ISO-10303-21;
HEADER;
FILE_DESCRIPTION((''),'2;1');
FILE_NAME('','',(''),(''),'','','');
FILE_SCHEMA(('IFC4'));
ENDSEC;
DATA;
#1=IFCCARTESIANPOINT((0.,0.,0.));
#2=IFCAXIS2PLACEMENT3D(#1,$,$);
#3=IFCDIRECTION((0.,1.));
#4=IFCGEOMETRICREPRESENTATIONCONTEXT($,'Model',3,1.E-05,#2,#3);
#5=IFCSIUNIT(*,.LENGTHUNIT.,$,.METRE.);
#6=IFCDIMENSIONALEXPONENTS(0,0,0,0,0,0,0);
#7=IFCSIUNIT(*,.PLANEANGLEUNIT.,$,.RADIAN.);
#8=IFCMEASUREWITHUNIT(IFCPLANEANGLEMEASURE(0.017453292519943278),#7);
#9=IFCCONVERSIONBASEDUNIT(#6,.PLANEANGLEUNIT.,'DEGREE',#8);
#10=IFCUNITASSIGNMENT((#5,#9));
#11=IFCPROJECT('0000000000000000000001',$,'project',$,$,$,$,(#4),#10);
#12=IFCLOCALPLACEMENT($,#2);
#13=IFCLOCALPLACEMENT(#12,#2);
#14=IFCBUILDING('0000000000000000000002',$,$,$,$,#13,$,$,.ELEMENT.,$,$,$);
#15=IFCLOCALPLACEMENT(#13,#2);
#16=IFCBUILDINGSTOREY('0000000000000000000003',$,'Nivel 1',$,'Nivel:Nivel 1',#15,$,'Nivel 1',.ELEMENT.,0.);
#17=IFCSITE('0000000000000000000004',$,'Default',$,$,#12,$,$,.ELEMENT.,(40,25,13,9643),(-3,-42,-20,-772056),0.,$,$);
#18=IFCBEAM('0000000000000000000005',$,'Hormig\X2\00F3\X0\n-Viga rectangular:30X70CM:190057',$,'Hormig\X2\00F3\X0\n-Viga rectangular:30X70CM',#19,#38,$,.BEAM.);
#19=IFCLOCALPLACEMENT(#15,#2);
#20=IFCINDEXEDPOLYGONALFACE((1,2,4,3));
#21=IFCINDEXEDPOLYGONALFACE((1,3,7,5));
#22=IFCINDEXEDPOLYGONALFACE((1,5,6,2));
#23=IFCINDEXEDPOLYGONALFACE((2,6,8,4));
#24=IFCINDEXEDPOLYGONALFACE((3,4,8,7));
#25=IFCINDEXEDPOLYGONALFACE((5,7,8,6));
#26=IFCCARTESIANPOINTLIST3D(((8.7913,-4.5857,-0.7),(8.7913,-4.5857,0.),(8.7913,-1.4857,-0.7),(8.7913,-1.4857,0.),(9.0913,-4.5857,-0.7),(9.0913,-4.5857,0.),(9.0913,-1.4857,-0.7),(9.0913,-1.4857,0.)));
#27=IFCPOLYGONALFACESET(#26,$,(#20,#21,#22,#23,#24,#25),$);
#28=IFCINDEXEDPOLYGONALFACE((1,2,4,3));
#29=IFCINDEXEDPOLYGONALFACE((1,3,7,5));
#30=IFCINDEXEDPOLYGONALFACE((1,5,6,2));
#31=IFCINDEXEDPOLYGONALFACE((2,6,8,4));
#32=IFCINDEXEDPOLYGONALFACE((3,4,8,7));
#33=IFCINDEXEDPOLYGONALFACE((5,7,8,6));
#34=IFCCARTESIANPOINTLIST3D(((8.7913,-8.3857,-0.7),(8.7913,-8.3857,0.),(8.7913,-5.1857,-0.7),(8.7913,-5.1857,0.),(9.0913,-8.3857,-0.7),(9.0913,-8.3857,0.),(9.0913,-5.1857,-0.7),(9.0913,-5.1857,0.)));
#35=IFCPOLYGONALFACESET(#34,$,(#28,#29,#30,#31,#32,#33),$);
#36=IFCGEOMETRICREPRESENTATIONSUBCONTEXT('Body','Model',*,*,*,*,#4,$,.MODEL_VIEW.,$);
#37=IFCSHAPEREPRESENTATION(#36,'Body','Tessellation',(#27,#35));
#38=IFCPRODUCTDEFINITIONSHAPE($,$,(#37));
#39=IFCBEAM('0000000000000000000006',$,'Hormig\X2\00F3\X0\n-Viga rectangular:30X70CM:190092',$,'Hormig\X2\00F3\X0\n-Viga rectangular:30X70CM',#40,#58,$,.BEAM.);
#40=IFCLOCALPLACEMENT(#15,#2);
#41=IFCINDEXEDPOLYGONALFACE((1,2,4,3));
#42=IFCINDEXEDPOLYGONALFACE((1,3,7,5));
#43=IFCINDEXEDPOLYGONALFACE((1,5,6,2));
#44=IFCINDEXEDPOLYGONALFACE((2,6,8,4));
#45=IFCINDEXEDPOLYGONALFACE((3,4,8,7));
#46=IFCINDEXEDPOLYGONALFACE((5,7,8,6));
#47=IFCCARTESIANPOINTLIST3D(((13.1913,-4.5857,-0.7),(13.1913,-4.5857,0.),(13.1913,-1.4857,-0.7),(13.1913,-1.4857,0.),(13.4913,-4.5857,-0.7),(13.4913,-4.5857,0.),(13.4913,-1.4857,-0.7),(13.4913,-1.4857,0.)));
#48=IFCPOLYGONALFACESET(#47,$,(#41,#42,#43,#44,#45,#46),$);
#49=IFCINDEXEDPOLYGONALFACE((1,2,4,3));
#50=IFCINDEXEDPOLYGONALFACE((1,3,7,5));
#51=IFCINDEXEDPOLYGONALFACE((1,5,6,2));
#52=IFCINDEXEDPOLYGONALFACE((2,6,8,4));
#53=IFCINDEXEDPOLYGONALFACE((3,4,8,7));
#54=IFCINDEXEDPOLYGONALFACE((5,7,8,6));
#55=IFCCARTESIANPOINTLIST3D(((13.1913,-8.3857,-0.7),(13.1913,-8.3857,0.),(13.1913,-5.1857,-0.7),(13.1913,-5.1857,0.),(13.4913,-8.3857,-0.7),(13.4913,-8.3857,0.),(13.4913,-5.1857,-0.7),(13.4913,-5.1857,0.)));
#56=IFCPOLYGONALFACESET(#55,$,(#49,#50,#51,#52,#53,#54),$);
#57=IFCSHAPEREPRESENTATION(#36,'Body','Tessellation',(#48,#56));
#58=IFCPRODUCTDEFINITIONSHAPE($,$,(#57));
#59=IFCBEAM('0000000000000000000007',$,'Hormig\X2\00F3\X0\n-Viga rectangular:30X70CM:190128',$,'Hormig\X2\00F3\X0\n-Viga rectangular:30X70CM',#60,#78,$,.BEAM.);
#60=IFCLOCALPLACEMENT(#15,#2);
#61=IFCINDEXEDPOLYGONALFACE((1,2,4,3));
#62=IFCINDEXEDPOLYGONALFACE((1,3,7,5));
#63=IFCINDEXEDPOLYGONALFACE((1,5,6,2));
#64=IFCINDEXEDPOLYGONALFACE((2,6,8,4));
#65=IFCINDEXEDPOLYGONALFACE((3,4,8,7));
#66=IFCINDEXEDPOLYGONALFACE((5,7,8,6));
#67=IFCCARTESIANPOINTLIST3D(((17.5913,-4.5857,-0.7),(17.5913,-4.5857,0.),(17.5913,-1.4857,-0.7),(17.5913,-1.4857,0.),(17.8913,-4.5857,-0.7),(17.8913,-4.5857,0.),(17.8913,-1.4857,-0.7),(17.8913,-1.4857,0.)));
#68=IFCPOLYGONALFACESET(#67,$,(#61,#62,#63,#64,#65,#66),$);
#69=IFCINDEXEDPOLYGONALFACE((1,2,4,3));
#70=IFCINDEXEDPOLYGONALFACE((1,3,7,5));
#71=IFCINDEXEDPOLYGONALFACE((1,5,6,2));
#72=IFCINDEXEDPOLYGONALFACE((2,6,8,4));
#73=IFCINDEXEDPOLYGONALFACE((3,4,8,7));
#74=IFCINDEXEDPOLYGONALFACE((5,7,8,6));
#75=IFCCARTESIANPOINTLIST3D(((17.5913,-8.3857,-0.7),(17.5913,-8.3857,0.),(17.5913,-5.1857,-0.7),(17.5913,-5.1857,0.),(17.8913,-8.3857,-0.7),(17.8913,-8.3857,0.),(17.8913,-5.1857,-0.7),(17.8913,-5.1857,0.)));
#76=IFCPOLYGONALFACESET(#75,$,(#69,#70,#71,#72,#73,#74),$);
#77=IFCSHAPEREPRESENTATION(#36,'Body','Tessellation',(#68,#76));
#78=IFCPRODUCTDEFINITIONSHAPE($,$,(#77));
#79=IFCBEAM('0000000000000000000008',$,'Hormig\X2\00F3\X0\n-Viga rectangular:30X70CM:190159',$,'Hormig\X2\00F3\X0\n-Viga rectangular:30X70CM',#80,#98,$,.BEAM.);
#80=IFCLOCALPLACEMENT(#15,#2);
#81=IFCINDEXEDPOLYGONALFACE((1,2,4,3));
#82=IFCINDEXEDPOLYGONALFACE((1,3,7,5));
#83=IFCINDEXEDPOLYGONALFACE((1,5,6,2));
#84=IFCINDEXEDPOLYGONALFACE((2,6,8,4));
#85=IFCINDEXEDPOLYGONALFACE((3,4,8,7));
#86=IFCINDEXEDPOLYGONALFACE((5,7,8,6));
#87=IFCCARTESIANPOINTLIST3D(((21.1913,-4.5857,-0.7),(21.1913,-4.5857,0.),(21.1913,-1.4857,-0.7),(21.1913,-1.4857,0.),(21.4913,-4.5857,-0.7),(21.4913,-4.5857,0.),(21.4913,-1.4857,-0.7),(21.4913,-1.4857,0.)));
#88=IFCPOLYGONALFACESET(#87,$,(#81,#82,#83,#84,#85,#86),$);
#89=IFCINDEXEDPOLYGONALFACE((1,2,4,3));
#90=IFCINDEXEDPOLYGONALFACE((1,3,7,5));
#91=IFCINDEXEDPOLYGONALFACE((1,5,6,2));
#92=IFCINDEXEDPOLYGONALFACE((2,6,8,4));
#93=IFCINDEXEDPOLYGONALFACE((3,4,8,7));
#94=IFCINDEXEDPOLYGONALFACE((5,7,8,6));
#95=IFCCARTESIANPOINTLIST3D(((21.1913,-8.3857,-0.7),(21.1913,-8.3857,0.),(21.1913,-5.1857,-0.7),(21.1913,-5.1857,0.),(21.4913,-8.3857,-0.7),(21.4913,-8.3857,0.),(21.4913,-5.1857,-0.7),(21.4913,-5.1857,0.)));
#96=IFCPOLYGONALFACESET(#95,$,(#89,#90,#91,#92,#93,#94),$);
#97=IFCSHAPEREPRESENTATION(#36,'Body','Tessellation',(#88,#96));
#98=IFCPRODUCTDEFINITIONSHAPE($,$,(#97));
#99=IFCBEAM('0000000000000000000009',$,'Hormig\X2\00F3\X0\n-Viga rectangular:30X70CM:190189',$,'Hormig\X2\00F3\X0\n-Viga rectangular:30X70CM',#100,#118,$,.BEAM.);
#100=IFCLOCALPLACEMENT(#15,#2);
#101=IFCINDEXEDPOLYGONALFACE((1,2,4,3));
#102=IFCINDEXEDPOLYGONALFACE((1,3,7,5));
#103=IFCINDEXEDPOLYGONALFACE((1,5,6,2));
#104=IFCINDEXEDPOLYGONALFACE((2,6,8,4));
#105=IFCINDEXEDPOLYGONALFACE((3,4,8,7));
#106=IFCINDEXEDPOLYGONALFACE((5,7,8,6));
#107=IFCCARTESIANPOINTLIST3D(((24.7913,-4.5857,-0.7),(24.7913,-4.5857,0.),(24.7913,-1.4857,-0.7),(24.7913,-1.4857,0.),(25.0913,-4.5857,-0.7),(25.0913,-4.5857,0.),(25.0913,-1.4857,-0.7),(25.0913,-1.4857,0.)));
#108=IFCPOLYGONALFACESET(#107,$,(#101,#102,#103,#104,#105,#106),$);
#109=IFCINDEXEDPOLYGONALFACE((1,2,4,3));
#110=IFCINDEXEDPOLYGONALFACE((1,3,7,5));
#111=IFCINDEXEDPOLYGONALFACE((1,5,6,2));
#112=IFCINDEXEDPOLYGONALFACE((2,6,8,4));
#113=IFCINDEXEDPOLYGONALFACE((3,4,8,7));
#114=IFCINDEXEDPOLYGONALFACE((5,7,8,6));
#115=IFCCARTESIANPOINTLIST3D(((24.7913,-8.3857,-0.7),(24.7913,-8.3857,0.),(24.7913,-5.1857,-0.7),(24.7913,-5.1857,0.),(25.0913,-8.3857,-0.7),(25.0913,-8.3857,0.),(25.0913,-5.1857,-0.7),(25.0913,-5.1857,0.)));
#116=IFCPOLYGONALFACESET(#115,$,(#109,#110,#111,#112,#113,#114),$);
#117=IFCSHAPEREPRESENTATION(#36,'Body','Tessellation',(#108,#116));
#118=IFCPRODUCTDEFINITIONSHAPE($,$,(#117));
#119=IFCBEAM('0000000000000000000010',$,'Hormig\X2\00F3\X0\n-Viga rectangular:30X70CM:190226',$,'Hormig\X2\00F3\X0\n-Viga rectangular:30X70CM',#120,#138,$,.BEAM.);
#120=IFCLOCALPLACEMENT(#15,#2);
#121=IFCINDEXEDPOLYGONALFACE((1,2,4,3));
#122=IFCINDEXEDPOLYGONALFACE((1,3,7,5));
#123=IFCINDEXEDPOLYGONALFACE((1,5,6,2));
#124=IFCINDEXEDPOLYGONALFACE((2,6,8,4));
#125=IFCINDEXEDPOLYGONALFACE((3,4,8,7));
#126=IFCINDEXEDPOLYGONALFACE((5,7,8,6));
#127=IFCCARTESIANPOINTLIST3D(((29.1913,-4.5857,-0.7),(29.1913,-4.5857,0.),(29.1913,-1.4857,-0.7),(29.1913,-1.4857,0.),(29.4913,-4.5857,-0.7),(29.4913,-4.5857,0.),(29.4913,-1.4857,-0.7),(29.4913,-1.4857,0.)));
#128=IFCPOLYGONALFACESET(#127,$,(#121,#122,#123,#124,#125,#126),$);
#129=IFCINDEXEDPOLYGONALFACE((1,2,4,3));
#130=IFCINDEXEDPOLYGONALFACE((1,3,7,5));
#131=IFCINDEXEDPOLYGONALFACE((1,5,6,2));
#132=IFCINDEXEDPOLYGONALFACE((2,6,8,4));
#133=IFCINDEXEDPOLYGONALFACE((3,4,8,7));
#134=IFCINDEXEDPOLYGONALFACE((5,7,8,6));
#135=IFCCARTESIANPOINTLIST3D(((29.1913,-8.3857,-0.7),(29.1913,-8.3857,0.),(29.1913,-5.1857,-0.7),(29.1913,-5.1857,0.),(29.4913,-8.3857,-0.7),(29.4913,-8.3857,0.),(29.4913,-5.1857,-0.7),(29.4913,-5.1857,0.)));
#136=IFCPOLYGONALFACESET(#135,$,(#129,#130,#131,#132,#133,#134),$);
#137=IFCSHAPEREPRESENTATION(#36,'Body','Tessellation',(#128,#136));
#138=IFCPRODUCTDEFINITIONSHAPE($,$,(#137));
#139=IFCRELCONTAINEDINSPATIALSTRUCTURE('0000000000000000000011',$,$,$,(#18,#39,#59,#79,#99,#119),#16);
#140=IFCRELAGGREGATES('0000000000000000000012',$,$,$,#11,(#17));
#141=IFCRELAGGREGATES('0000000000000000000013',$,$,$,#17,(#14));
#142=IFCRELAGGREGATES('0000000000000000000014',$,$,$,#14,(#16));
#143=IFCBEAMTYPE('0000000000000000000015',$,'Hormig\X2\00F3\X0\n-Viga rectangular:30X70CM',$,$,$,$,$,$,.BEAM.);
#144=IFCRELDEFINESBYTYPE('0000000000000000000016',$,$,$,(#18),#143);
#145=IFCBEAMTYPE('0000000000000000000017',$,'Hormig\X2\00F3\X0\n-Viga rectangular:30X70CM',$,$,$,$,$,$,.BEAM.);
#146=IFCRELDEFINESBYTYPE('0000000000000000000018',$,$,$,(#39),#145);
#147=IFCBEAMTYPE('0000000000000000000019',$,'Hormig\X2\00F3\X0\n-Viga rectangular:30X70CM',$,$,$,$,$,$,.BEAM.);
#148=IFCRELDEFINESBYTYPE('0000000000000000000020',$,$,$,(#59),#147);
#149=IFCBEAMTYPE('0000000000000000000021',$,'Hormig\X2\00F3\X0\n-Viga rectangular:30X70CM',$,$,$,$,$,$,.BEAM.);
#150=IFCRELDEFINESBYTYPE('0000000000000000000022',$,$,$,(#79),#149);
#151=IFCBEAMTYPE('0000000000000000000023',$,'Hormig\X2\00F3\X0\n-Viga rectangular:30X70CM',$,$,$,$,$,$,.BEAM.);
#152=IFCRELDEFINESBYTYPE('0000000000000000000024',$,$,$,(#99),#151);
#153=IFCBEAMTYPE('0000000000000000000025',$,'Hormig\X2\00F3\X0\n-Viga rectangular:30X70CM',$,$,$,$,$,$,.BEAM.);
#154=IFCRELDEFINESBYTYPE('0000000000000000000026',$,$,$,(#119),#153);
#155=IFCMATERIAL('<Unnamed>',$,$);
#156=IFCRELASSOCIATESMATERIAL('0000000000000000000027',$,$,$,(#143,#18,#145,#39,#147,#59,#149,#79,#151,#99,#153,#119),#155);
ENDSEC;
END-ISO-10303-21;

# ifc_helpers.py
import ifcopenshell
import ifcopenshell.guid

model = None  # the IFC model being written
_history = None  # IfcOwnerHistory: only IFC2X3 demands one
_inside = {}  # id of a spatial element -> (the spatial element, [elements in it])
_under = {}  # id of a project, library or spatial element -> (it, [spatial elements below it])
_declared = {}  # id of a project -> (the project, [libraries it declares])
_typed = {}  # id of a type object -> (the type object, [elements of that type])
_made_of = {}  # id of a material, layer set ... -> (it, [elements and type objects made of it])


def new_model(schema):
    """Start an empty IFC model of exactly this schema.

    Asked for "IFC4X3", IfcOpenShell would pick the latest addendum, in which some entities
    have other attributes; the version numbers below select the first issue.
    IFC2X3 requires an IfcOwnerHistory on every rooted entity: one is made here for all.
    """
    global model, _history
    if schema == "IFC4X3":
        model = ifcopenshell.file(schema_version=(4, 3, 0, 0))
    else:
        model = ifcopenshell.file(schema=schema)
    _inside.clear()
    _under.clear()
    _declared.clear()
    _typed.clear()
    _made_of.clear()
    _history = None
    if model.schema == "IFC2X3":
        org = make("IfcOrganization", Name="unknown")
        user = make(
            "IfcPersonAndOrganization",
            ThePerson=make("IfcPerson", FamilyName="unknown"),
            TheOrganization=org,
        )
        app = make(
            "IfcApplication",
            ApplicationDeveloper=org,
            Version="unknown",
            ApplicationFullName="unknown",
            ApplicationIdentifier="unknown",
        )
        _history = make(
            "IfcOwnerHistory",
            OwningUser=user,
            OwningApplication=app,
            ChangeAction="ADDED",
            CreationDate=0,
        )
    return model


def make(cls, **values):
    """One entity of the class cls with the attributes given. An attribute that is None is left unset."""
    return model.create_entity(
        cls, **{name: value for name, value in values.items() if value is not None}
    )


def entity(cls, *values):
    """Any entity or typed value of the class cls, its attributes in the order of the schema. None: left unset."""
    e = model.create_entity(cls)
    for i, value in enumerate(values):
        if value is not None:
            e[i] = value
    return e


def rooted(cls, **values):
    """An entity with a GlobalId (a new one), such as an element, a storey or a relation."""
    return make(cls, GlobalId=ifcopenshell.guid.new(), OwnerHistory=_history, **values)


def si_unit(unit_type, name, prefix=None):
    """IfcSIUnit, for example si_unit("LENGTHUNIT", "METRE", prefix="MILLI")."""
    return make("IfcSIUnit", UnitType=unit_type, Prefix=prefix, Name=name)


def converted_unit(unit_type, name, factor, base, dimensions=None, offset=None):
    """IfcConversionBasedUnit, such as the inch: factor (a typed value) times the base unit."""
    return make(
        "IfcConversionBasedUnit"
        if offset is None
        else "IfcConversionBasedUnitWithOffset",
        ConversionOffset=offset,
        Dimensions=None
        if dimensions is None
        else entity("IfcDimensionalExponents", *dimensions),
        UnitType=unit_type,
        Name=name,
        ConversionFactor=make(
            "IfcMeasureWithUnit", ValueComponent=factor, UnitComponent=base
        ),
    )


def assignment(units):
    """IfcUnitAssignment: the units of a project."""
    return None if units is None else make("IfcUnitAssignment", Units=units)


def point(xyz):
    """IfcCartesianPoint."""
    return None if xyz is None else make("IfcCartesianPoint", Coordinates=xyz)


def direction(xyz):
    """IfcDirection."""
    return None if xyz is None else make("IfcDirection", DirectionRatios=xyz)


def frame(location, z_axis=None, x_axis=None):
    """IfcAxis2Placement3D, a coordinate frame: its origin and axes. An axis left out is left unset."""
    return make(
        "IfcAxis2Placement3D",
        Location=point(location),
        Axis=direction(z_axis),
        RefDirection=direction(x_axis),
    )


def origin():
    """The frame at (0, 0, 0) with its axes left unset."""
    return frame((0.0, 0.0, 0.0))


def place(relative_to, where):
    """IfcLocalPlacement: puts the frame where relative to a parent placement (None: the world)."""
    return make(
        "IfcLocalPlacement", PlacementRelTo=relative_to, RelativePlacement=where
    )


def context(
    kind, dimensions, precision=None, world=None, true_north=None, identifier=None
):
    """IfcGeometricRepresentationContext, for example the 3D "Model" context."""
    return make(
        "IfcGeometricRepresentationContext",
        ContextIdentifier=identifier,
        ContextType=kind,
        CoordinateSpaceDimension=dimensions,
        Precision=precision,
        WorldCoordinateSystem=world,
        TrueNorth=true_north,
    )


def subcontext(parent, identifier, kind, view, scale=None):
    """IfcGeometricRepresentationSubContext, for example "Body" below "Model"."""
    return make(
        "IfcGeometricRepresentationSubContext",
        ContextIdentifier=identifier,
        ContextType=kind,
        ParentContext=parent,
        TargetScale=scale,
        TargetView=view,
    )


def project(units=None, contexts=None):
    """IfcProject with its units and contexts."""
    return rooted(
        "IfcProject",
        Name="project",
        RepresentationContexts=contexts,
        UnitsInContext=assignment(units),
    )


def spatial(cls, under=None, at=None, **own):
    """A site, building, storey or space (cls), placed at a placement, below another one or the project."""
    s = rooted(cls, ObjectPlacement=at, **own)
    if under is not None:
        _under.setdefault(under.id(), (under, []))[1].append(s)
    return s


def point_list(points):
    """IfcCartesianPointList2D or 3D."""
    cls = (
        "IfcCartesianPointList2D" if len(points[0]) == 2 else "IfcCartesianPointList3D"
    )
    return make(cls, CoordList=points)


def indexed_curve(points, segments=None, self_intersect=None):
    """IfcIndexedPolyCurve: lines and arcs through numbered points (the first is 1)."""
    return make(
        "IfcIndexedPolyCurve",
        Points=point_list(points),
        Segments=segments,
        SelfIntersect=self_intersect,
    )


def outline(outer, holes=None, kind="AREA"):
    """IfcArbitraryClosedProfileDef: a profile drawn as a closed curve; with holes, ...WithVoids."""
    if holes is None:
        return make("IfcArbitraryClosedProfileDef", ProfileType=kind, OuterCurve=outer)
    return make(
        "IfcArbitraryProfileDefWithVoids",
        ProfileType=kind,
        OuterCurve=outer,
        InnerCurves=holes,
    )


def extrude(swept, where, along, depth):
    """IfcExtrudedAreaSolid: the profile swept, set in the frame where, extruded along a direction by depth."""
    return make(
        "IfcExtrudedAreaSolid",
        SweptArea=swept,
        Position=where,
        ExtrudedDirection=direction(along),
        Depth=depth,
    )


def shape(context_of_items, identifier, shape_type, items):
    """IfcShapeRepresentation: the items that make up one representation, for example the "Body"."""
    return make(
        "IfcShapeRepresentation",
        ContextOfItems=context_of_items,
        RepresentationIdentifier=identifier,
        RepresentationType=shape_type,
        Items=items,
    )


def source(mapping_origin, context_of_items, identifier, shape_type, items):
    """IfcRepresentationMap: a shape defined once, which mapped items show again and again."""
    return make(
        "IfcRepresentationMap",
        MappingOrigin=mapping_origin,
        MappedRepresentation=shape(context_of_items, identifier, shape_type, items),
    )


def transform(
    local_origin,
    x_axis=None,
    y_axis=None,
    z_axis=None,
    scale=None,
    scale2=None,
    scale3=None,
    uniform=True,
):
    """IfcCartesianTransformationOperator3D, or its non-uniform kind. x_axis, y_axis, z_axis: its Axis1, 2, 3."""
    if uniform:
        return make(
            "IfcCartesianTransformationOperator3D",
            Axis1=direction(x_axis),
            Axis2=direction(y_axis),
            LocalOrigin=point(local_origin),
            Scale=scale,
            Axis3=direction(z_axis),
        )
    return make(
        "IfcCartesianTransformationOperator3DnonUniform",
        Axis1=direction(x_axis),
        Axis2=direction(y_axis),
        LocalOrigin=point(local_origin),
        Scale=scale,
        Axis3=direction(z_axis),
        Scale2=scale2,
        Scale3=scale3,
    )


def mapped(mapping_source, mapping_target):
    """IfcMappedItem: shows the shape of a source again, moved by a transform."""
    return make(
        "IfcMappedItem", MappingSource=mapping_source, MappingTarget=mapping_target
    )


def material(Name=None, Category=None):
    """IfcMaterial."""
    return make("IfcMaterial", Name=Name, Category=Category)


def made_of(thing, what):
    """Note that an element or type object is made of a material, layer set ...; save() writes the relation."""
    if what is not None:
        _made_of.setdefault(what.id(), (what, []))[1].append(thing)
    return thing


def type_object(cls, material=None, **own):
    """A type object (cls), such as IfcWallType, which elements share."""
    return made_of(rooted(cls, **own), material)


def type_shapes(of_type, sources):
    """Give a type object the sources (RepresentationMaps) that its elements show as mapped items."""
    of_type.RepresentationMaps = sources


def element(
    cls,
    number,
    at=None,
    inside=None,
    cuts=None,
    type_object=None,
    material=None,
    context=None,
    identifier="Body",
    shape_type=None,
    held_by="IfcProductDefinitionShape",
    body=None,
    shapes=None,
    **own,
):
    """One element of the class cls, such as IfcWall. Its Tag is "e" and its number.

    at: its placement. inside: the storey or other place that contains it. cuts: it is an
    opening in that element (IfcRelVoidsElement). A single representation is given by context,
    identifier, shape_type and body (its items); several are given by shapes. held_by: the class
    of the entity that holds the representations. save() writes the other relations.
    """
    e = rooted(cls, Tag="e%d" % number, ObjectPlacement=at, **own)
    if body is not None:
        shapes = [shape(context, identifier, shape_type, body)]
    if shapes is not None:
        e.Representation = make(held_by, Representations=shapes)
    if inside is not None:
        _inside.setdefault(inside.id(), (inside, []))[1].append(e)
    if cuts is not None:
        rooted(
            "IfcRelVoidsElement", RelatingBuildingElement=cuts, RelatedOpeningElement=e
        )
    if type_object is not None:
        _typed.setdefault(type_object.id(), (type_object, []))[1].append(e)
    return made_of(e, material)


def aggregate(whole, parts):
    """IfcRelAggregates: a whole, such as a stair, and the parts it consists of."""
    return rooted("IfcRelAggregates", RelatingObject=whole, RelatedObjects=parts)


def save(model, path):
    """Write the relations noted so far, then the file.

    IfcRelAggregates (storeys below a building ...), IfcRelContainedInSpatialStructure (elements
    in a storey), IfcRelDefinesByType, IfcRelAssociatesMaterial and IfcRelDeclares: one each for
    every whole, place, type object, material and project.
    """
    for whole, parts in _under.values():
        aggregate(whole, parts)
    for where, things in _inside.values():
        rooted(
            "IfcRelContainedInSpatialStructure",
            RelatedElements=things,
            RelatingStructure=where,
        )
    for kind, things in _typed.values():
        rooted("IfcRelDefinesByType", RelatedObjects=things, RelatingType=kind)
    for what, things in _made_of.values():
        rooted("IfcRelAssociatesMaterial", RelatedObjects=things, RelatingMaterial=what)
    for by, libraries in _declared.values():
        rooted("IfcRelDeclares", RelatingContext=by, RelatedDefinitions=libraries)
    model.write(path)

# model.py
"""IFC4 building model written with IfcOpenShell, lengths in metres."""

from ifc_helpers import new_model, entity, si_unit, converted_unit, direction, frame, origin, place, context, subcontext, project, spatial, indexed_curve, outline, extrude, source, transform, mapped, material, type_object, type_shapes, element, save


model = new_model("IFC4")

# Units and contexts
model_context = context("Model", 3, precision=1e-05, world=origin(), true_north=direction((0.0, 1.0)))
body_context = subcontext(model_context, "Body", "Model", "MODEL_VIEW")
ifc_project = project(units=[si_unit("LENGTHUNIT", "METRE"), converted_unit("PLANEANGLEUNIT", "DEGREE", entity("IfcPlaneAngleMeasure", 0.017453292519943278), si_unit("PLANEANGLEUNIT", "RADIAN"), dimensions=[0, 0, 0, 0, 0, 0, 0])], contexts=[model_context])

# Site, building, storey
site_placement = place(None, origin())
site = spatial("IfcSite", under=ifc_project, at=site_placement, Name="Default", CompositionType="ELEMENT", RefLatitude=(40, 25, 13, 9643), RefLongitude=(-3, -42, -20, -772056), RefElevation=0.0)
building_placement = place(site_placement, origin())
building = spatial("IfcBuilding", under=site, at=building_placement, CompositionType="ELEMENT")
storey_placement = place(building_placement, origin())
storey = spatial("IfcBuildingStorey", under=building, at=storey_placement, Name="Nivel 1", ObjectType="Nivel:Nivel 1", LongName="Nivel 1", CompositionType="ELEMENT", Elevation=0.0)

# Beams
ifc_material_1 = material(Name="<Unnamed>")
beam_type_1 = type_object("IfcBeamType", Name="Hormigón-Viga rectangular:30X70CM", PredefinedType="BEAM", material=ifc_material_1)
shared_shape_1 = source(origin(), body_context, "Body", "SweptSolid", [
    extrude(outline(indexed_curve([(-0.15, -0.35), (0.15, -0.35), (0.15, 0.35), (-0.15, 0.35), (-0.15, -0.35)], self_intersect=False)), frame((8.9413, -1.4857, -0.35), z_axis=(0.0, -1.0, 0.0), x_axis=(-1.0, 0.0, 0.0)), (0.0, 0.0, 1.0), 3.1),
    extrude(outline(indexed_curve([(-0.15, -0.35), (0.15, -0.35), (0.15, 0.35), (-0.15, 0.35), (-0.15, -0.35)], self_intersect=False)), frame((8.9413, -5.1857, -0.35), z_axis=(0.0, -1.0, 0.0), x_axis=(-1.0, 0.0, 0.0)), (0.0, 0.0, 1.0), 3.2),
])
type_shapes(beam_type_1, [shared_shape_1])
beam_1_placement = place(storey_placement, origin())
element("IfcBeam", 1, at=beam_1_placement, inside=storey, type_object=beam_type_1, material=ifc_material_1, Name="Hormigón-Viga rectangular:30X70CM:190057", ObjectType="Hormigón-Viga rectangular:30X70CM", PredefinedType="BEAM", context=body_context, shape_type="MappedRepresentation", body=[
    mapped(shared_shape_1, transform((0.0, 0.0, 0.0), scale=1.0)),
])
beam_type_2 = type_object("IfcBeamType", Name="Hormigón-Viga rectangular:30X70CM", PredefinedType="BEAM", material=ifc_material_1)
shared_shape_2 = source(origin(), body_context, "Body", "SweptSolid", [
    extrude(outline(indexed_curve([(-0.15, -0.35), (0.15, -0.35), (0.15, 0.35), (-0.15, 0.35), (-0.15, -0.35)], self_intersect=False)), frame((13.3413, -1.4857, -0.35), z_axis=(0.0, -1.0, 0.0), x_axis=(-1.0, 0.0, 0.0)), (0.0, 0.0, 1.0), 3.1),
    extrude(outline(indexed_curve([(-0.15, -0.35), (0.15, -0.35), (0.15, 0.35), (-0.15, 0.35), (-0.15, -0.35)], self_intersect=False)), frame((13.3413, -5.1857, -0.35), z_axis=(0.0, -1.0, 0.0), x_axis=(-1.0, 0.0, 0.0)), (0.0, 0.0, 1.0), 3.2),
])
type_shapes(beam_type_2, [shared_shape_2])
beam_2_placement = place(storey_placement, origin())
element("IfcBeam", 2, at=beam_2_placement, inside=storey, type_object=beam_type_2, material=ifc_material_1, Name="Hormigón-Viga rectangular:30X70CM:190092", ObjectType="Hormigón-Viga rectangular:30X70CM", PredefinedType="BEAM", context=body_context, shape_type="MappedRepresentation", body=[
    mapped(shared_shape_2, transform((0.0, 0.0, 0.0), scale=1.0)),
])
beam_type_3 = type_object("IfcBeamType", Name="Hormigón-Viga rectangular:30X70CM", PredefinedType="BEAM", material=ifc_material_1)
shared_shape_3 = source(origin(), body_context, "Body", "SweptSolid", [
    extrude(outline(indexed_curve([(-0.15, -0.35), (0.15, -0.35), (0.15, 0.35), (-0.15, 0.35), (-0.15, -0.35)], self_intersect=False)), frame((17.7413, -1.4857, -0.35), z_axis=(0.0, -1.0, 0.0), x_axis=(-1.0, 0.0, 0.0)), (0.0, 0.0, 1.0), 3.1),
    extrude(outline(indexed_curve([(-0.15, -0.35), (0.15, -0.35), (0.15, 0.35), (-0.15, 0.35), (-0.15, -0.35)], self_intersect=False)), frame((17.7413, -5.1857, -0.35), z_axis=(0.0, -1.0, 0.0), x_axis=(-1.0, 0.0, 0.0)), (0.0, 0.0, 1.0), 3.2),
])
type_shapes(beam_type_3, [shared_shape_3])
beam_3_placement = place(storey_placement, origin())
element("IfcBeam", 3, at=beam_3_placement, inside=storey, type_object=beam_type_3, material=ifc_material_1, Name="Hormigón-Viga rectangular:30X70CM:190128", ObjectType="Hormigón-Viga rectangular:30X70CM", PredefinedType="BEAM", context=body_context, shape_type="MappedRepresentation", body=[
    mapped(shared_shape_3, transform((0.0, 0.0, 0.0), scale=1.0)),
])
beam_type_4 = type_object("IfcBeamType", Name="Hormigón-Viga rectangular:30X70CM", PredefinedType="BEAM", material=ifc_material_1)
shared_shape_4 = source(origin(), body_context, "Body", "SweptSolid", [
    extrude(outline(indexed_curve([(-0.15, -0.35), (0.15, -0.35), (0.15, 0.35), (-0.15, 0.35), (-0.15, -0.35)], self_intersect=False)), frame((21.3413, -1.4857, -0.35), z_axis=(0.0, -1.0, 0.0), x_axis=(-1.0, 0.0, 0.0)), (0.0, 0.0, 1.0), 3.1),
    extrude(outline(indexed_curve([(-0.15, -0.35), (0.15, -0.35), (0.15, 0.35), (-0.15, 0.35), (-0.15, -0.35)], self_intersect=False)), frame((21.3413, -5.1857, -0.35), z_axis=(0.0, -1.0, 0.0), x_axis=(-1.0, 0.0, 0.0)), (0.0, 0.0, 1.0), 3.2),
])
type_shapes(beam_type_4, [shared_shape_4])
beam_4_placement = place(storey_placement, origin())
element("IfcBeam", 4, at=beam_4_placement, inside=storey, type_object=beam_type_4, material=ifc_material_1, Name="Hormigón-Viga rectangular:30X70CM:190159", ObjectType="Hormigón-Viga rectangular:30X70CM", PredefinedType="BEAM", context=body_context, shape_type="MappedRepresentation", body=[
    mapped(shared_shape_4, transform((0.0, 0.0, 0.0), scale=1.0)),
])
beam_type_5 = type_object("IfcBeamType", Name="Hormigón-Viga rectangular:30X70CM", PredefinedType="BEAM", material=ifc_material_1)
shared_shape_5 = source(origin(), body_context, "Body", "SweptSolid", [
    extrude(outline(indexed_curve([(-0.15, -0.35), (0.15, -0.35), (0.15, 0.35), (-0.15, 0.35), (-0.15, -0.35)], self_intersect=False)), frame((24.9413, -1.4857, -0.35), z_axis=(0.0, -1.0, 0.0), x_axis=(-1.0, 0.0, 0.0)), (0.0, 0.0, 1.0), 3.1),
    extrude(outline(indexed_curve([(-0.15, -0.35), (0.15, -0.35), (0.15, 0.35), (-0.15, 0.35), (-0.15, -0.35)], self_intersect=False)), frame((24.9413, -5.1857, -0.35), z_axis=(0.0, -1.0, 0.0), x_axis=(-1.0, 0.0, 0.0)), (0.0, 0.0, 1.0), 3.2),
])
type_shapes(beam_type_5, [shared_shape_5])
beam_5_placement = place(storey_placement, origin())
element("IfcBeam", 5, at=beam_5_placement, inside=storey, type_object=beam_type_5, material=ifc_material_1, Name="Hormigón-Viga rectangular:30X70CM:190189", ObjectType="Hormigón-Viga rectangular:30X70CM", PredefinedType="BEAM", context=body_context, shape_type="MappedRepresentation", body=[
    mapped(shared_shape_5, transform((0.0, 0.0, 0.0), scale=1.0)),
])
beam_type_6 = type_object("IfcBeamType", Name="Hormigón-Viga rectangular:30X70CM", PredefinedType="BEAM", material=ifc_material_1)
shared_shape_6 = source(origin(), body_context, "Body", "SweptSolid", [
    extrude(outline(indexed_curve([(-0.15, -0.35), (0.15, -0.35), (0.15, 0.35), (-0.15, 0.35), (-0.15, -0.35)], self_intersect=False)), frame((29.3413, -1.4857, -0.35), z_axis=(0.0, -1.0, 0.0), x_axis=(-1.0, 0.0, 0.0)), (0.0, 0.0, 1.0), 3.1),
    extrude(outline(indexed_curve([(-0.15, -0.35), (0.15, -0.35), (0.15, 0.35), (-0.15, 0.35), (-0.15, -0.35)], self_intersect=False)), frame((29.3413, -5.1857, -0.35), z_axis=(0.0, -1.0, 0.0), x_axis=(-1.0, 0.0, 0.0)), (0.0, 0.0, 1.0), 3.2),
])
type_shapes(beam_type_6, [shared_shape_6])
beam_6_placement = place(storey_placement, origin())
element("IfcBeam", 6, at=beam_6_placement, inside=storey, type_object=beam_type_6, material=ifc_material_1, Name="Hormigón-Viga rectangular:30X70CM:190226", ObjectType="Hormigón-Viga rectangular:30X70CM", PredefinedType="BEAM", context=body_context, shape_type="MappedRepresentation", body=[
    mapped(shared_shape_6, transform((0.0, 0.0, 0.0), scale=1.0)),
])

save(model, "model.ifc")
